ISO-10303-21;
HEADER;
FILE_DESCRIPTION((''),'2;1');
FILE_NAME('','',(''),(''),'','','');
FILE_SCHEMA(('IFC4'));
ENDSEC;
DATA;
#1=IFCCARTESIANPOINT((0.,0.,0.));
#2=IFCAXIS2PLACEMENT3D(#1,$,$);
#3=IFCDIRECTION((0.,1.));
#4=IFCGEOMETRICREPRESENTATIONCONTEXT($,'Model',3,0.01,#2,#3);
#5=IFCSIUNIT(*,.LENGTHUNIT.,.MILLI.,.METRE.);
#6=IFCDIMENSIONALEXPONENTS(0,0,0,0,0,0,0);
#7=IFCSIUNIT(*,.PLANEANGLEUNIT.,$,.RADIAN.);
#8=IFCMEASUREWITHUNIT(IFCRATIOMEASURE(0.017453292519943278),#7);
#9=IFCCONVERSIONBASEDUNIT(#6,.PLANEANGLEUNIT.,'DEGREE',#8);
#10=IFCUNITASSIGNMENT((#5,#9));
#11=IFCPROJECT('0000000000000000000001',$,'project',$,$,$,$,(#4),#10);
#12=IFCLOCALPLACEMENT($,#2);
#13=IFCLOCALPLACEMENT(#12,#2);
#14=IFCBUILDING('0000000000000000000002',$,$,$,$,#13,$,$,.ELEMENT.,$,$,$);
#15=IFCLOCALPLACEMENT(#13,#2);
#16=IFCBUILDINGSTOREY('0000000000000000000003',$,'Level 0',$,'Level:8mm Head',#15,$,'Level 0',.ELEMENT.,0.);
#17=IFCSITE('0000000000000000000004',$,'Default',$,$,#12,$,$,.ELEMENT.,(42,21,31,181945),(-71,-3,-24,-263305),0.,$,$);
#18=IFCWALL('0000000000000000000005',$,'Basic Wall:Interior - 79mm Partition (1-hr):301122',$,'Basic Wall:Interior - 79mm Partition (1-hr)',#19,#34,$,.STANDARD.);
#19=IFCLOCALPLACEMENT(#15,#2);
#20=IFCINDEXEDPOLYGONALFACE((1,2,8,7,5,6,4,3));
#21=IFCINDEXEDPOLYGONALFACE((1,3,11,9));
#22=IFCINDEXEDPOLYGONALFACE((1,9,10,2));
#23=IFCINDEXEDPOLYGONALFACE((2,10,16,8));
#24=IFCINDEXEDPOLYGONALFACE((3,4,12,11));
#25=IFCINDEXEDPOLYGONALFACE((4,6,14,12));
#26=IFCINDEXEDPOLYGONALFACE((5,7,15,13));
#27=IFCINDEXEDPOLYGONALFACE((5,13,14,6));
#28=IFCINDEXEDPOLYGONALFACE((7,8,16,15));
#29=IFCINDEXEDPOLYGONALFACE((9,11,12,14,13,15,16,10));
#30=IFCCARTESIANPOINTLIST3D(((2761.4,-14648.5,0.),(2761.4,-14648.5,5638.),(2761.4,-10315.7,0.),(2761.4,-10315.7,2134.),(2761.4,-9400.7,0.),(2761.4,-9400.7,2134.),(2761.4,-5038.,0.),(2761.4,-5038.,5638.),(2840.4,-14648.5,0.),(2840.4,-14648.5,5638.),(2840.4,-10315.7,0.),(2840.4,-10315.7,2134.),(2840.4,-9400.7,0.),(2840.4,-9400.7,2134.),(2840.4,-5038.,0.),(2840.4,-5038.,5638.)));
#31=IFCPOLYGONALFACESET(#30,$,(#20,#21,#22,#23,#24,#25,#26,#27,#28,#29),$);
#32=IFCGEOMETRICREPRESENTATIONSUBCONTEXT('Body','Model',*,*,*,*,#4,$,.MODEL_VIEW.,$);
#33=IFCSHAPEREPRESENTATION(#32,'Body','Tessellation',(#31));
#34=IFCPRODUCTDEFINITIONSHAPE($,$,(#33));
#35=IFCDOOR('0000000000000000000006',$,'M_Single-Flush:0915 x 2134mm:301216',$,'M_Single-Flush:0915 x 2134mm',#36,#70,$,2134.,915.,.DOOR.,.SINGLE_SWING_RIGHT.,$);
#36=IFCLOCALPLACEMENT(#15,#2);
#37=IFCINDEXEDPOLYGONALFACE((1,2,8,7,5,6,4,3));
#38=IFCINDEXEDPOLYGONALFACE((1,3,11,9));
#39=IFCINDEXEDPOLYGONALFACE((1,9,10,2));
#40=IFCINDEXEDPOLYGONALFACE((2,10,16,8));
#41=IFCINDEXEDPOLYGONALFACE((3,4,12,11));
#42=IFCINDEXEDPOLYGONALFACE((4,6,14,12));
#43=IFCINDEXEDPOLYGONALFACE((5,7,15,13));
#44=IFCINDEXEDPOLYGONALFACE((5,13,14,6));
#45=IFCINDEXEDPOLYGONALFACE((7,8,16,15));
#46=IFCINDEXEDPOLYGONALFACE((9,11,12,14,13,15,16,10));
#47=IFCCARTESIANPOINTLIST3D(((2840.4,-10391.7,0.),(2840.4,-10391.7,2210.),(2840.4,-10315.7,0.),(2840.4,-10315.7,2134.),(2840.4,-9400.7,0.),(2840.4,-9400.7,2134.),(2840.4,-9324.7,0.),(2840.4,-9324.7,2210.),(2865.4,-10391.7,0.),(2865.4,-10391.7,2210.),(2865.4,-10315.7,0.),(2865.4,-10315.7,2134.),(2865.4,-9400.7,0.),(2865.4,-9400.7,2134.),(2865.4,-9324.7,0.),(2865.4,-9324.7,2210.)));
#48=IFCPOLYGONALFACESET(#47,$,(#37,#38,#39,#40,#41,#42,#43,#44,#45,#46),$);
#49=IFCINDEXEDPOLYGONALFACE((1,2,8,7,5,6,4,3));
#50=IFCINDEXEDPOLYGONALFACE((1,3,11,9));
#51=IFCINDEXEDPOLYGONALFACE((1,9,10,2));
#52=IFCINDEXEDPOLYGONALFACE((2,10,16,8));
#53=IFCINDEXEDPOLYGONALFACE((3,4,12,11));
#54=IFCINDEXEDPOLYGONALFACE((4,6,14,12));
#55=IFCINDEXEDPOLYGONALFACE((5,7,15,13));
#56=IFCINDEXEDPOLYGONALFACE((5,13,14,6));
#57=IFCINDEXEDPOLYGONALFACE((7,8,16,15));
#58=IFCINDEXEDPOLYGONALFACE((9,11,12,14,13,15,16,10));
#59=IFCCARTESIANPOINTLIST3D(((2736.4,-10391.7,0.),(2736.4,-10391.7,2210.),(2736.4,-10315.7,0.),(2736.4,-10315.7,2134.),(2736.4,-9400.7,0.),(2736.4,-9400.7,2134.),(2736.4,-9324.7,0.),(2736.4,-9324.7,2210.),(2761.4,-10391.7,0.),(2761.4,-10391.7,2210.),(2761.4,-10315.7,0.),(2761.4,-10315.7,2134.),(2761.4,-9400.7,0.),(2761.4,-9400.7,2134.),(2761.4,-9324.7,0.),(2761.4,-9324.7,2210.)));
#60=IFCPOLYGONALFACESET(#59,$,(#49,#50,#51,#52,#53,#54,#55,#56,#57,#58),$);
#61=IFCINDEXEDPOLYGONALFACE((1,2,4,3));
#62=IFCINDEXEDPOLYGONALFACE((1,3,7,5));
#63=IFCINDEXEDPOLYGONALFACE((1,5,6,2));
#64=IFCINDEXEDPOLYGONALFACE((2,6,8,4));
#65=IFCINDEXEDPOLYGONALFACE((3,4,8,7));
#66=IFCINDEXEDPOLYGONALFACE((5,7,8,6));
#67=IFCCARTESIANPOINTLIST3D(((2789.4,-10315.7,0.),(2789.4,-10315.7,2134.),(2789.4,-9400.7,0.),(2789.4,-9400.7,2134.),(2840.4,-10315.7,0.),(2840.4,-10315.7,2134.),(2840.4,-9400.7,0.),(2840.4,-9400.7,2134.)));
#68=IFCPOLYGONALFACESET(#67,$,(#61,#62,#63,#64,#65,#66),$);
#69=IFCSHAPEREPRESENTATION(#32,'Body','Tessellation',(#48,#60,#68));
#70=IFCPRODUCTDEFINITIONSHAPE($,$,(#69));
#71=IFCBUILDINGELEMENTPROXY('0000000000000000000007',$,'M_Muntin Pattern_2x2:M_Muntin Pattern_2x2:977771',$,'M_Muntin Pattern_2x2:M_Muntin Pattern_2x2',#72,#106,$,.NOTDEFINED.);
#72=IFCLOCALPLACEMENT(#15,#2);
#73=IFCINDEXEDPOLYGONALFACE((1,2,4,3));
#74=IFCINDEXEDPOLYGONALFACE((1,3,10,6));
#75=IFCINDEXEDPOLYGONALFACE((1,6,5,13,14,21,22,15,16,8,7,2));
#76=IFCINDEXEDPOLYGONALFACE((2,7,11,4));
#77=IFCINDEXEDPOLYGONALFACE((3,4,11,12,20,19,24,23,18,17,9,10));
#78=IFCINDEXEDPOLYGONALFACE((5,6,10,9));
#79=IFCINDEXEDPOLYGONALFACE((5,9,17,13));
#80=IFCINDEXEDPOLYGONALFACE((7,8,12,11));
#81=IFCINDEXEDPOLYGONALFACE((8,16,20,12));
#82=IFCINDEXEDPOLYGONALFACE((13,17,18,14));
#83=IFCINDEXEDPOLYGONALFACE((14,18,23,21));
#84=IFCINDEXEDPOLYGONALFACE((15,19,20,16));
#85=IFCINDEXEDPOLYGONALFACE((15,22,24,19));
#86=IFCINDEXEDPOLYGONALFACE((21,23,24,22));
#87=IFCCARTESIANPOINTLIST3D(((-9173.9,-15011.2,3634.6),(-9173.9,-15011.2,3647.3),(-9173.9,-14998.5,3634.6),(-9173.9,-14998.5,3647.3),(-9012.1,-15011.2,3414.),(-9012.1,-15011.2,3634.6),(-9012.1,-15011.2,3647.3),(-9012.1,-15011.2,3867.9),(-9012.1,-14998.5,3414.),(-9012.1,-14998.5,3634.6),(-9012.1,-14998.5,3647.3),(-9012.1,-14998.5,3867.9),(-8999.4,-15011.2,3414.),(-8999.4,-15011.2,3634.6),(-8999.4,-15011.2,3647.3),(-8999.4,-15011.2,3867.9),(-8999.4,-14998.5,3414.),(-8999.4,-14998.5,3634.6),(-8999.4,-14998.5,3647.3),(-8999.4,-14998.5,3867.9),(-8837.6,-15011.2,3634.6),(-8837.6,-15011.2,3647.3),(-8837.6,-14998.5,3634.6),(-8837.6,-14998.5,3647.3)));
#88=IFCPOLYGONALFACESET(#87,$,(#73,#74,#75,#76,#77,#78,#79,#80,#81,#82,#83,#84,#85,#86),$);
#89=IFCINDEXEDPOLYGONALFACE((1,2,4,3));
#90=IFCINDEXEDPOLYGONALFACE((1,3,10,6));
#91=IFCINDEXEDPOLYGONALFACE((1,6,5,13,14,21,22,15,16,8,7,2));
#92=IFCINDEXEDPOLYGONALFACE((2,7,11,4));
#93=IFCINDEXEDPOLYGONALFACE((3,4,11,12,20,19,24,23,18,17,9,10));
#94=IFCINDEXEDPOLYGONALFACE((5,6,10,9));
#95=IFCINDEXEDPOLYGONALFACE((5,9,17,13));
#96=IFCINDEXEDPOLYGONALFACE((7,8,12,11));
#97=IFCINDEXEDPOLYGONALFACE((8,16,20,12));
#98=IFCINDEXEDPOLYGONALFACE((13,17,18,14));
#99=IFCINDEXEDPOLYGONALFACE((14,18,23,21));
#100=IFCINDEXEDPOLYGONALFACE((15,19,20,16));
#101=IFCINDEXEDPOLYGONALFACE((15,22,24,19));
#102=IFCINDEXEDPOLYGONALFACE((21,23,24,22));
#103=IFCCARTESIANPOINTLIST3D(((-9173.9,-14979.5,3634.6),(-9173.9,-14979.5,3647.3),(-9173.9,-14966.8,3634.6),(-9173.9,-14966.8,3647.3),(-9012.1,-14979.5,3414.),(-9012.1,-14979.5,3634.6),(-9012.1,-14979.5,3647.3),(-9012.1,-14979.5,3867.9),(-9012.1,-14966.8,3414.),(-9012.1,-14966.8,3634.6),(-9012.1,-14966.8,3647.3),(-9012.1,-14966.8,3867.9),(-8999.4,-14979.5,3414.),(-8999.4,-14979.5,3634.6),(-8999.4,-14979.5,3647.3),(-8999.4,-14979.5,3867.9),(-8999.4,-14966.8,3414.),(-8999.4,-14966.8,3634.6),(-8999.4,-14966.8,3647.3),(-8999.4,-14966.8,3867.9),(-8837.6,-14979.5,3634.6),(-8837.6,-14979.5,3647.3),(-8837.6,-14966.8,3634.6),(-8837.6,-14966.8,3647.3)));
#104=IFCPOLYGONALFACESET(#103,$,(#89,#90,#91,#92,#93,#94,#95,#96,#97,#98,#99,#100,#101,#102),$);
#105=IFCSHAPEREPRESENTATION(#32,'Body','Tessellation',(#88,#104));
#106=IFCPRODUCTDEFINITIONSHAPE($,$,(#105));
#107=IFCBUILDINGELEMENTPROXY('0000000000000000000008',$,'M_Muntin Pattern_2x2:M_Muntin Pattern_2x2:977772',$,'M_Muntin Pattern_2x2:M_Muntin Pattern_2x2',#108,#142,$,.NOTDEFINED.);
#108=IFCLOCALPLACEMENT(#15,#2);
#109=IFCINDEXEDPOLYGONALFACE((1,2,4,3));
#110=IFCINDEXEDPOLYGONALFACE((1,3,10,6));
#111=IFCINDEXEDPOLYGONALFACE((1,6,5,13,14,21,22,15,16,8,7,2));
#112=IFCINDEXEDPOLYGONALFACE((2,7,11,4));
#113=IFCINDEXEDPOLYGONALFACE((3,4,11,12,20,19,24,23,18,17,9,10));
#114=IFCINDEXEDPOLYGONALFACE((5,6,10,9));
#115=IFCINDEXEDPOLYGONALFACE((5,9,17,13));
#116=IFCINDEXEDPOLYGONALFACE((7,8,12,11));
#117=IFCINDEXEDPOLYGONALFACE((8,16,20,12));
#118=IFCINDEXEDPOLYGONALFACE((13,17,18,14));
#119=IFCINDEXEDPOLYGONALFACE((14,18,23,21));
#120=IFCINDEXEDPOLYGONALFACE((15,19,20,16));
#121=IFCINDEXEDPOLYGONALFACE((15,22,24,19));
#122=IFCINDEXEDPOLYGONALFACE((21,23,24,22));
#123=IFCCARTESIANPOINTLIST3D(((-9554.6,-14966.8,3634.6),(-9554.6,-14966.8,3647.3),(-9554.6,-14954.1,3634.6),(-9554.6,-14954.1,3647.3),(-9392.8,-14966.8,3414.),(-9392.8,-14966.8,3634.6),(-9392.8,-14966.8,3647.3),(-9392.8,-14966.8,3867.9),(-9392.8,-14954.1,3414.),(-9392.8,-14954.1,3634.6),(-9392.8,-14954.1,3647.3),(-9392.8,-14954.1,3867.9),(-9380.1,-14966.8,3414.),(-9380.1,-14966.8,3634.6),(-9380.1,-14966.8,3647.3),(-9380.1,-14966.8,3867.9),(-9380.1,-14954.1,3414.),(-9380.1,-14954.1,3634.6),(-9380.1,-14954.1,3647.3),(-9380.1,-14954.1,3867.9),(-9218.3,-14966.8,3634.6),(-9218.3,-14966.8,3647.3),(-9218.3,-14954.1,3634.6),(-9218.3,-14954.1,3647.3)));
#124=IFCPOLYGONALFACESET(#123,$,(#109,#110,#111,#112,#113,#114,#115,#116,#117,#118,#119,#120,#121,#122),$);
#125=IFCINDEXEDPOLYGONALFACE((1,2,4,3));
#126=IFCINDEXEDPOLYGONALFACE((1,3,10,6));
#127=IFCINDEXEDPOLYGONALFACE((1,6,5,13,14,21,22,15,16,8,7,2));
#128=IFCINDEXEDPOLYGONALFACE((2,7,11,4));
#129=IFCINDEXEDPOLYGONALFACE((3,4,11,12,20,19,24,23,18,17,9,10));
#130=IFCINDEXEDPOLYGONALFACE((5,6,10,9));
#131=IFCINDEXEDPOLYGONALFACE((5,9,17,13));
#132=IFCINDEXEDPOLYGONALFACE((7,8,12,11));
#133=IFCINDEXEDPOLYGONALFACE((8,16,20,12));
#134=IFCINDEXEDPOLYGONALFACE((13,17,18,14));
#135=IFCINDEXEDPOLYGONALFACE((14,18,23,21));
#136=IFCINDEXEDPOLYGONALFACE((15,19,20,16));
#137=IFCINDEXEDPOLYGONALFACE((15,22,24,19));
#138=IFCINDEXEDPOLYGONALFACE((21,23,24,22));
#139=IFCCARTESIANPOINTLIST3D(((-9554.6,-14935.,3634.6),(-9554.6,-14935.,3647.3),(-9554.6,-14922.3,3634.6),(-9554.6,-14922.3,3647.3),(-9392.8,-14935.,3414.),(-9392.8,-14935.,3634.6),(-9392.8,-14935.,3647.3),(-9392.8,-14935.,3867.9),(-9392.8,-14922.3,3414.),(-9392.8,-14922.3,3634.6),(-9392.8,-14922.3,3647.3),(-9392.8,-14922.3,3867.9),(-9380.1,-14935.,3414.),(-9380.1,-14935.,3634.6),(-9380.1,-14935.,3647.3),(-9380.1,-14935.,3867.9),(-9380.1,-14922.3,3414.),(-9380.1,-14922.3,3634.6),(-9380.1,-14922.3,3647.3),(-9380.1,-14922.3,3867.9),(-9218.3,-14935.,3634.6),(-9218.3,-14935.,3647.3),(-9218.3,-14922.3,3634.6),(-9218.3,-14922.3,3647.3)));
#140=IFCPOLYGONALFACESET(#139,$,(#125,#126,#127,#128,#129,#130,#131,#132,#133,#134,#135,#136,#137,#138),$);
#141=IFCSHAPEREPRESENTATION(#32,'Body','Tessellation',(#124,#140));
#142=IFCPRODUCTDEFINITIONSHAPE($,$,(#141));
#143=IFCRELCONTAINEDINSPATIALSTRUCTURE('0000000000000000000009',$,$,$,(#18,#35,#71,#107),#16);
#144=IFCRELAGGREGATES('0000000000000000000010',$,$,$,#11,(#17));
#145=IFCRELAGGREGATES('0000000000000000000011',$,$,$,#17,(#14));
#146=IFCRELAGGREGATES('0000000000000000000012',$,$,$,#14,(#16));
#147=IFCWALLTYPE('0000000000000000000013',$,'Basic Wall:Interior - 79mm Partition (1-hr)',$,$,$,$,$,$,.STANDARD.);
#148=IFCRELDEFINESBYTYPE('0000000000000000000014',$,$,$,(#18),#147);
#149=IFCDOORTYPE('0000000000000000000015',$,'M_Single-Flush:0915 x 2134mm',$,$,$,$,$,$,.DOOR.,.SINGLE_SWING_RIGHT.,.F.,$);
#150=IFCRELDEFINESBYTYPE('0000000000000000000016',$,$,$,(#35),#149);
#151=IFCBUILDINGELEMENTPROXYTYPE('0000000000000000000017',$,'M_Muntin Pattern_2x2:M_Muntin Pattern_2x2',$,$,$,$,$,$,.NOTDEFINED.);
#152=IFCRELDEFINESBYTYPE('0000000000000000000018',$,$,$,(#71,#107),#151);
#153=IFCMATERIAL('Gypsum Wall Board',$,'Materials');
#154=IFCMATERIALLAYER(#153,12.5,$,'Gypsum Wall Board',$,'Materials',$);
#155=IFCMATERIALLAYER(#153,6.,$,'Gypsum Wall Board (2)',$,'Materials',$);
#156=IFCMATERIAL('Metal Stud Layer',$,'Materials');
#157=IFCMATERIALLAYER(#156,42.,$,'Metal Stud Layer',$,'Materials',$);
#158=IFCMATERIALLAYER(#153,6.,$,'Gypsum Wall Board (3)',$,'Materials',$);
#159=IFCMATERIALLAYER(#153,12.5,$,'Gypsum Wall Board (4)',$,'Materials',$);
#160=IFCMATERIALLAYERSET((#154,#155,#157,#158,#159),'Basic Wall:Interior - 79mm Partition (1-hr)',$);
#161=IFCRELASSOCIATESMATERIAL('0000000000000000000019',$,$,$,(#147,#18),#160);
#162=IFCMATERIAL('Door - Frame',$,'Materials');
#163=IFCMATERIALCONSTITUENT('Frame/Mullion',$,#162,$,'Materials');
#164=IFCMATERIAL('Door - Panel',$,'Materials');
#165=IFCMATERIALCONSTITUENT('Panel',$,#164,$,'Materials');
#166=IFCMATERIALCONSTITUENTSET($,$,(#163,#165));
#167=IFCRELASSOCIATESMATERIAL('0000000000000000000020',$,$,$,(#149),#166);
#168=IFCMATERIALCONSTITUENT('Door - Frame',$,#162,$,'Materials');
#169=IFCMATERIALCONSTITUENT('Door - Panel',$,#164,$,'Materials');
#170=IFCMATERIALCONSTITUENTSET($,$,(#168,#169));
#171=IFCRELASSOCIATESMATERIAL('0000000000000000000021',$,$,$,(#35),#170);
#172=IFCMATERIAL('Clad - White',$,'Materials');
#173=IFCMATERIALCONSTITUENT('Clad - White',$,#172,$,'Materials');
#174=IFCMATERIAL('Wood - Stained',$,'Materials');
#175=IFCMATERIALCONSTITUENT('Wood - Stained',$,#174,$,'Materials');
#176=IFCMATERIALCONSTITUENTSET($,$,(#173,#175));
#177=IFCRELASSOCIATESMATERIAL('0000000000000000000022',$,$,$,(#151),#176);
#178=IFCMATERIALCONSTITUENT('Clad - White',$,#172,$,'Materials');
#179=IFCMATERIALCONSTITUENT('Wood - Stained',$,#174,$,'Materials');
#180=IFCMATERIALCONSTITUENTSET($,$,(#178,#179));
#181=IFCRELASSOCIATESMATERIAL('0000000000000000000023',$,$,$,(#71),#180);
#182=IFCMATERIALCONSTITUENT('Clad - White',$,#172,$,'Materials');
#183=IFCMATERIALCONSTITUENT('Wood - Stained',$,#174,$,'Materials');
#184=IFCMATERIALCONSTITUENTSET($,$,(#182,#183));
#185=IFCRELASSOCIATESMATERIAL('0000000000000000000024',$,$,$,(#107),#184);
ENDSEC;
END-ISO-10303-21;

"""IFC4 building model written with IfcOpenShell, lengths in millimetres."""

from ifc_helpers import new_model, entity, si_unit, converted_unit, direction, frame, frame_2d, origin, origin_2d_with_axis, place, context, subcontext, project, spatial, polyline, rectangle, outline, extrude, clip, bounded_halfspace, source, transform, mapped, material, layer, layer_set, layer_usage, constituent, constituent_set, type_object, type_shapes, element, fill, save


model = new_model("IFC4")

# Units and contexts
model_context = context("Model", 3, precision=0.01, world=origin(), true_north=direction((0.0, 1.0)))
body_context = subcontext(model_context, "Body", "Model", "MODEL_VIEW")
ifc_project = project(units=[si_unit("LENGTHUNIT", "METRE", prefix="MILLI"), converted_unit("PLANEANGLEUNIT", "DEGREE", entity("IfcRatioMeasure", 0.017453292519943278), si_unit("PLANEANGLEUNIT", "RADIAN"), dimensions=[0, 0, 0, 0, 0, 0, 0])], contexts=[model_context])

# Site, building, storey
site_placement = place(None, origin())
site = spatial("IfcSite", under=ifc_project, at=site_placement, Name="Default", CompositionType="ELEMENT", RefLatitude=(42, 21, 31, 181945), RefLongitude=(-71, -3, -24, -263305), RefElevation=0.0)
building_placement = place(site_placement, origin())
building = spatial("IfcBuilding", under=site, at=building_placement, CompositionType="ELEMENT")
storey_placement = place(building_placement, origin())
storey = spatial("IfcBuildingStorey", under=building, at=storey_placement, Name="Level 0", ObjectType="Level:8mm Head", LongName="Level 0", CompositionType="ELEMENT", Elevation=0.0)

# Shared definitions
ifc_material_1 = material(Name="Metal Stud Layer", Category="Materials")
ifc_material_2 = material(Name="Gypsum Wall Board", Category="Materials")
ifc_material_3 = material(Name="Door - Frame", Category="Materials")
ifc_material_4 = material(Name="Door - Panel", Category="Materials")

# Wall, opening, door
ifc_layer_1 = layer(ifc_material_2, 12.5, Name="Gypsum Wall Board", Category="Materials")
ifc_layer_2 = layer(ifc_material_2, 6.0, Name="Gypsum Wall Board (2)", Category="Materials")
ifc_layer_3 = layer(ifc_material_1, 42.0, Name="Metal Stud Layer", Category="Materials")
ifc_layer_4 = layer(ifc_material_2, 6.0, Name="Gypsum Wall Board (3)", Category="Materials")
ifc_layer_5 = layer(ifc_material_2, 12.5, Name="Gypsum Wall Board (4)", Category="Materials")
ifc_layer_set_1 = layer_set([ifc_layer_1, ifc_layer_2, ifc_layer_3, ifc_layer_4, ifc_layer_5], Name="Basic Wall:Interior - 79mm Partition (1-hr)")
ifc_layer_usage_1 = layer_usage(ifc_layer_set_1, "AXIS2", "NEGATIVE", 39.5)
wall_type_1 = type_object("IfcWallType", Name="Basic Wall:Interior - 79mm Partition (1-hr)", PredefinedType="STANDARD", material=ifc_layer_set_1)
ifc_constituent_1 = constituent(ifc_material_3, Name="Frame/Mullion", Category="Materials")
ifc_constituent_2 = constituent(ifc_material_4, Name="Panel", Category="Materials")
ifc_constituent_set_1 = constituent_set(constituents=[ifc_constituent_1, ifc_constituent_2])
door_type_1 = type_object("IfcDoorType", Name="M_Single-Flush:0915 x 2134mm", OperationType="SINGLE_SWING_RIGHT", ParameterTakesPrecedence=False, PredefinedType="DOOR", material=ifc_constituent_set_1)
shared_shape_1 = source(origin(), body_context, "Body", "SweptSolid", [
    extrude(outline(polyline([(-533.5, -1124.0), (533.5, -1124.0), (533.5, 1086.0), (457.5, 1086.0), (457.5, -1048.0), (-457.5, -1048.0), (-457.5, 1086.0), (-533.5, 1086.0), (-533.5, -1124.0)])), frame((457.5, 79.0, 1086.0), z_axis=(0.0, 1.0, 0.0), x_axis=(1.0, 0.0, 0.0)), (0.0, 0.0, 1.0), 25.0),
    extrude(outline(polyline([(-1124.0, -533.5), (1086.0, -533.5), (1086.0, -457.5), (-1048.0, -457.5), (-1048.0, 457.5), (1086.0, 457.5), (1086.0, 533.5), (-1124.0, 533.5), (-1124.0, -533.5)])), frame((457.5, -25.0, 1086.0), z_axis=(0.0, 1.0, 0.0), x_axis=(0.0, 0.0, -1.0)), (0.0, 0.0, 1.0), 25.0),
    extrude(rectangle(XDim=51.0, YDim=915.0, at=origin_2d_with_axis()), frame((457.5, 53.5, 0.0), z_axis=(0.0, 0.0, 1.0), x_axis=(0.0, 1.0, 0.0)), (0.0, 0.0, 1.0), 2134.0),
])
type_shapes(door_type_1, [shared_shape_1])
wall_1_placement = place(storey_placement, frame((2800.9, -5038.0, 0.0), z_axis=(0.0, 0.0, 1.0), x_axis=(0.0, -1.0, 0.0)))
wall_1 = element("IfcWall", 1, at=wall_1_placement, inside=storey, type_object=wall_type_1, material=ifc_layer_usage_1, Name="Basic Wall:Interior - 79mm Partition (1-hr):301122", ObjectType="Basic Wall:Interior - 79mm Partition (1-hr)", PredefinedType="STANDARD", context=body_context, shape_type="Clipping", body=[
    clip(extrude(rectangle(XDim=9610.5, YDim=79.0, at=frame_2d((4805.3, 0.0), x_axis=(-1.0, 0.0))), origin(), (0.0, 0.0, 1.0), 5638.0), bounded_halfspace(frame((0.0, -39.5, 5638.0), z_axis=(0.0, 0.0, -1.0), x_axis=(1.0, 0.0, 0.0)), True, frame((0.0, -39.5, 5638.0)), polyline([(0.0, 0.0), (2929280.4, 0.0), (2929280.4, 24079.2), (0.0, 24079.2), (0.0, 0.0)]))),
])
opening_1_placement = place(wall_1_placement, frame((4362.6, -39.5, 0.0)))
opening_1 = element("IfcOpeningElement", 2, at=opening_1_placement, cuts=wall_1, PredefinedType="OPENING", context=body_context, shape_type="SweptSolid", body=[
    extrude(rectangle(XDim=915.0, YDim=2134.0, at=frame_2d((1067.0, 457.5), x_axis=(0.0, 1.0))), frame((0.0, 0.0, 0.0), z_axis=(0.0, 1.0, 0.0), x_axis=(0.0, 0.0, 1.0)), (0.0, 0.0, 1.0), 79.0),
])
ifc_constituent_3 = constituent(ifc_material_3, Name="Door - Frame", Category="Materials")
ifc_constituent_4 = constituent(ifc_material_4, Name="Door - Panel", Category="Materials")
ifc_constituent_set_2 = constituent_set(constituents=[ifc_constituent_3, ifc_constituent_4])
door_1_placement = place(opening_1_placement, origin())
door_1 = element("IfcDoor", 3, at=door_1_placement, inside=storey, type_object=door_type_1, material=ifc_constituent_set_2, Name="M_Single-Flush:0915 x 2134mm:301216", ObjectType="M_Single-Flush:0915 x 2134mm", OperationType="SINGLE_SWING_RIGHT", OverallHeight=2134.0, OverallWidth=915.0, PredefinedType="DOOR", context=body_context, shape_type="MappedRepresentation", body=[
    mapped(shared_shape_1, transform((0.0, 0.0, 0.0), scale=1.0)),
])
fill(opening_1, door_1)

# Building element proxies
ifc_material_5 = material(Name="Clad - White", Category="Materials")
ifc_constituent_5 = constituent(ifc_material_5, Name="Clad - White", Category="Materials")
ifc_material_6 = material(Name="Wood - Stained", Category="Materials")
ifc_constituent_6 = constituent(ifc_material_6, Name="Wood - Stained", Category="Materials")
ifc_constituent_set_3 = constituent_set(constituents=[ifc_constituent_5, ifc_constituent_6])
ifc_constituent_7 = constituent(ifc_material_5, Name="Clad - White", Category="Materials")
ifc_constituent_8 = constituent(ifc_material_6, Name="Wood - Stained", Category="Materials")
ifc_constituent_set_4 = constituent_set(constituents=[ifc_constituent_7, ifc_constituent_8])
building_element_proxy_type_1 = type_object("IfcBuildingElementProxyType", Name="M_Muntin Pattern_2x2:M_Muntin Pattern_2x2", PredefinedType="NOTDEFINED", material=ifc_constituent_set_4)
shared_shape_2 = source(origin(), body_context, "Body", "SweptSolid", [
    extrude(outline(polyline([(6.4, -6.4), (227.0, -6.4), (227.0, 6.3), (6.4, 6.3), (6.4, 168.2), (-6.3, 168.2), (-6.3, 6.3), (-227.0, 6.3), (-227.0, -6.4), (-6.3, -6.4), (-6.3, -168.1), (6.4, -168.1), (6.4, -6.4)])), frame((0.0, 9.5, 227.0), z_axis=(0.0, 1.0, 0.0), x_axis=(0.0, 0.0, 1.0)), (0.0, 0.0, 1.0), 12.7),
    extrude(outline(polyline([(6.4, -6.4), (227.0, -6.4), (227.0, 6.3), (6.4, 6.3), (6.4, 168.2), (-6.3, 168.2), (-6.3, 6.3), (-227.0, 6.3), (-227.0, -6.4), (-6.3, -6.4), (-6.3, -168.1), (6.4, -168.1), (6.4, -6.4)])), frame((0.0, -22.2, 227.0), z_axis=(0.0, 1.0, 0.0), x_axis=(0.0, 0.0, 1.0)), (0.0, 0.0, 1.0), 12.7),
])
type_shapes(building_element_proxy_type_1, [shared_shape_2])
proxy_1_placement = place(storey_placement, frame((-9005.7, -14989.0, 3414.0), z_axis=(0.0, 0.0, 1.0), x_axis=(-1.0, 0.0, 0.0)))
element("IfcBuildingElementProxy", 4, at=proxy_1_placement, inside=storey, type_object=building_element_proxy_type_1, material=ifc_constituent_set_3, Name="M_Muntin Pattern_2x2:M_Muntin Pattern_2x2:977771", ObjectType="M_Muntin Pattern_2x2:M_Muntin Pattern_2x2", PredefinedType="NOTDEFINED", context=body_context, shape_type="MappedRepresentation", body=[
    mapped(shared_shape_2, transform((0.0, 0.0, 0.0), scale=1.0)),
])
ifc_constituent_9 = constituent(ifc_material_5, Name="Clad - White", Category="Materials")
ifc_constituent_10 = constituent(ifc_material_6, Name="Wood - Stained", Category="Materials")
ifc_constituent_set_5 = constituent_set(constituents=[ifc_constituent_9, ifc_constituent_10])
proxy_2_placement = place(storey_placement, frame((-9386.5, -14944.6, 3414.0), z_axis=(0.0, 0.0, 1.0), x_axis=(-1.0, 0.0, 0.0)))
element("IfcBuildingElementProxy", 5, at=proxy_2_placement, inside=storey, type_object=building_element_proxy_type_1, material=ifc_constituent_set_5, Name="M_Muntin Pattern_2x2:M_Muntin Pattern_2x2:977772", ObjectType="M_Muntin Pattern_2x2:M_Muntin Pattern_2x2", PredefinedType="NOTDEFINED", context=body_context, shape_type="MappedRepresentation", body=[
    mapped(shared_shape_2, transform((0.0, 0.0, 0.0), scale=1.0)),
])

save(model, "model.ifc")
